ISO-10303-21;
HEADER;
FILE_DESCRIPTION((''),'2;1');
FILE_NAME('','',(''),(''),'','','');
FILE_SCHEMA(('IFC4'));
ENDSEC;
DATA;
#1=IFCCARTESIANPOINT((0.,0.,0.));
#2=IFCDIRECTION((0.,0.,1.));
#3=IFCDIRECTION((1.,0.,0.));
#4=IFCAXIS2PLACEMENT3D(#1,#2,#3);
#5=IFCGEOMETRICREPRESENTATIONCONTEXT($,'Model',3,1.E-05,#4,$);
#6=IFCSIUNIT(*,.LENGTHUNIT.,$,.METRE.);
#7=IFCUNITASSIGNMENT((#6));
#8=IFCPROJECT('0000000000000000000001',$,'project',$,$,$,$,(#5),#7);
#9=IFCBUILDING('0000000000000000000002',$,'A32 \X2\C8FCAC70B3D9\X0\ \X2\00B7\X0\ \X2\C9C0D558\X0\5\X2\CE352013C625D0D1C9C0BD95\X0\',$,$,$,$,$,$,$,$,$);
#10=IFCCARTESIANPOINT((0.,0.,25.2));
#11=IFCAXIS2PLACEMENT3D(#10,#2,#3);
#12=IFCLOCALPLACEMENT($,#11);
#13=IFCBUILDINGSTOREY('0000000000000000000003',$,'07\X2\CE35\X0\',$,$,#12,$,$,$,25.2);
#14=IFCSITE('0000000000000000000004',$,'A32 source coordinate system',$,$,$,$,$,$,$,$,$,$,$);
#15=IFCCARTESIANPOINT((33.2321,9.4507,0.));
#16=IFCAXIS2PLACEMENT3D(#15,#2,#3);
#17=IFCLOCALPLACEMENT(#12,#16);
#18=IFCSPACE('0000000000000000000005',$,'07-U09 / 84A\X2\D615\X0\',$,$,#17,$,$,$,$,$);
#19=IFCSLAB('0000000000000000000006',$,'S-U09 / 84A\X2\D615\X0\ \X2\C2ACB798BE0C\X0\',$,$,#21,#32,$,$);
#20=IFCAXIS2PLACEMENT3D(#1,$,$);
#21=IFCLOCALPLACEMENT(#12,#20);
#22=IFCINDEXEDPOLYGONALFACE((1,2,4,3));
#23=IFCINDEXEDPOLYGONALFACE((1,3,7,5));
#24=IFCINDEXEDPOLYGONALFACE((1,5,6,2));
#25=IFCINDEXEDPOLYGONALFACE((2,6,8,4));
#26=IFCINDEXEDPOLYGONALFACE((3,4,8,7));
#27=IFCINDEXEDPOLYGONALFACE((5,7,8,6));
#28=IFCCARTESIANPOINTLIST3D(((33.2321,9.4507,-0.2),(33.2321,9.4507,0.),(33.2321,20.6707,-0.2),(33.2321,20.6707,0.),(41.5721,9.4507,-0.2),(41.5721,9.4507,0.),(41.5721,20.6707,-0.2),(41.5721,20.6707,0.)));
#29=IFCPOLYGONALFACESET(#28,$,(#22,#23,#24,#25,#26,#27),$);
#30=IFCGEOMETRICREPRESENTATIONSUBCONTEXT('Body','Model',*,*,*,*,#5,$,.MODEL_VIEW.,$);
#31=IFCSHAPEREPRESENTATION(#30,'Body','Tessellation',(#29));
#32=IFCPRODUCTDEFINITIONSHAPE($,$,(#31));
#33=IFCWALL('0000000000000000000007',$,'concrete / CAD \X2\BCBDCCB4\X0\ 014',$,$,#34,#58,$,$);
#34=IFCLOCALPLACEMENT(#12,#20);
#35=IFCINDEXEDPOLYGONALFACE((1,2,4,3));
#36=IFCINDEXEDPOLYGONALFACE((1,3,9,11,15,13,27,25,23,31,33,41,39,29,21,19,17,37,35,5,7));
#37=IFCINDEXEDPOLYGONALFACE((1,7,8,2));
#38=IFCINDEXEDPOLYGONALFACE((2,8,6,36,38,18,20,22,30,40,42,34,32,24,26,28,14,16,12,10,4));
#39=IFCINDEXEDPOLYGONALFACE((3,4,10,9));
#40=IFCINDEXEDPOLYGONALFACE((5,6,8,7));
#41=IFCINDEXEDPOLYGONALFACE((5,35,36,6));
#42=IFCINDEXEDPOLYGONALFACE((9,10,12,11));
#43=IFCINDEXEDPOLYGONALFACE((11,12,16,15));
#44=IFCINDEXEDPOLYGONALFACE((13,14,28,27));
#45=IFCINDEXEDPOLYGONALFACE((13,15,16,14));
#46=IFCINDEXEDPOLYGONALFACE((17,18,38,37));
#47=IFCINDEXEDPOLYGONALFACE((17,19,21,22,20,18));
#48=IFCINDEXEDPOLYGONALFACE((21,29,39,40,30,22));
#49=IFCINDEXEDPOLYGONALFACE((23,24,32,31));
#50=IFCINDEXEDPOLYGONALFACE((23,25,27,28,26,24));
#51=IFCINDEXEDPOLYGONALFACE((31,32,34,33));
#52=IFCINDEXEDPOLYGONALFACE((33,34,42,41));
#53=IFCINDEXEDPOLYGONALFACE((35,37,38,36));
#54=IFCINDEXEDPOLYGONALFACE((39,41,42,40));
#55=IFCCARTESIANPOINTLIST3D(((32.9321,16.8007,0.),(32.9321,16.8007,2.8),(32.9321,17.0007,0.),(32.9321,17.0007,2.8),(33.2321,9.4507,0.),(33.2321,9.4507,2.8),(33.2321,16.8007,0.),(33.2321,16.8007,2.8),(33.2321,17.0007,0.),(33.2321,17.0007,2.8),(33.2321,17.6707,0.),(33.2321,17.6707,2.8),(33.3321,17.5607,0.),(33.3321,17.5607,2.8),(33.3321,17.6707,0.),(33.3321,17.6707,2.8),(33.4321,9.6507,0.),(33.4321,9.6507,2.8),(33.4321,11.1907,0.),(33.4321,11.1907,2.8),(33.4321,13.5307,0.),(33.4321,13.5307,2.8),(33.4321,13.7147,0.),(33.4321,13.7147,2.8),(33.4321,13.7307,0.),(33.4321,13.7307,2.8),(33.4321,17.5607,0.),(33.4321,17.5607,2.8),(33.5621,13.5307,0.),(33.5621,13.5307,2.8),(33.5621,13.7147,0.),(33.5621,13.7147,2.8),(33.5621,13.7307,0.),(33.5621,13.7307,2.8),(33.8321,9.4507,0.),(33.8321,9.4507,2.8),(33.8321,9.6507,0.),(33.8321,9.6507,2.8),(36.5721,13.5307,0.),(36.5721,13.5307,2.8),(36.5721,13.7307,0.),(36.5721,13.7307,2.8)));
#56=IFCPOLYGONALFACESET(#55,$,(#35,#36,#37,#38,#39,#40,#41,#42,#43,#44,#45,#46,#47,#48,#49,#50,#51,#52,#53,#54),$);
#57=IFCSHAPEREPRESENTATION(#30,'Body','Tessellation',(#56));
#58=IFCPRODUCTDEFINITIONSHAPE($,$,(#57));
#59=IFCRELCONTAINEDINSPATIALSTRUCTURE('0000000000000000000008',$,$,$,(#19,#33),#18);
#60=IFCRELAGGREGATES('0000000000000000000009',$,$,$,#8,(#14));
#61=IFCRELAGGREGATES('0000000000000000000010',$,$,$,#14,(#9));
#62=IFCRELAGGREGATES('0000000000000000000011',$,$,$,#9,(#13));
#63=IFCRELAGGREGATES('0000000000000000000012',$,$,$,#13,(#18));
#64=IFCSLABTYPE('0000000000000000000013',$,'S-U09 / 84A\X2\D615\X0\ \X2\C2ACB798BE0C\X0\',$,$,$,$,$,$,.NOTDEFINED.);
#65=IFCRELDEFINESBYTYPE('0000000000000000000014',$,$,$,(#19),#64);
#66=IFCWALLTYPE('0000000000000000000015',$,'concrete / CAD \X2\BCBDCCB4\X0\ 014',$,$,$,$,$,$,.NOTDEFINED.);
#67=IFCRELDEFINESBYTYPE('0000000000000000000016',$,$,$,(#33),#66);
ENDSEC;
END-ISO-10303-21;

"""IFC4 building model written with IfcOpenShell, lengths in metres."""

from ifc_helpers import new_model, si_unit, frame, origin, origin_with_axes, place, context, subcontext, project, spatial, polyline, outline, extrude, source, transform, mapped, type_object, type_shapes, element, save


model = new_model("IFC4")

# Units and contexts
model_context = context("Model", 3, precision=1e-05, world=origin_with_axes())
body_context = subcontext(model_context, "Body", "Model", "MODEL_VIEW")
ifc_project = project(units=[si_unit("LENGTHUNIT", "METRE")], contexts=[model_context])

# Site, building, storey, space
storey_placement = place(None, frame((0.0, 0.0, 25.2), z_axis=(0.0, 0.0, 1.0), x_axis=(1.0, 0.0, 0.0)))
space_placement = place(storey_placement, frame((33.2321, 9.4507, 0.0), z_axis=(0.0, 0.0, 1.0), x_axis=(1.0, 0.0, 0.0)))
site = spatial("IfcSite", under=ifc_project, Name="A32 source coordinate system")
building = spatial("IfcBuilding", under=site, Name="A32 주거동 · 지하5층–옥탑지붕")
storey = spatial("IfcBuildingStorey", under=building, at=storey_placement, Name="07층", Elevation=25.2)
space = spatial("IfcSpace", under=storey, at=space_placement, Name="07-U09 / 84A형")

# Slab
slab_type_1 = type_object("IfcSlabType", Name="S-U09 / 84A형 슬래브", PredefinedType="NOTDEFINED")
shared_shape_1 = source(origin(), body_context, "Body", "SweptSolid", [
    extrude(outline(polyline([(0.0, 11.22), (8.34, 11.22), (8.34, 0.0), (0.0, 0.0), (0.0, 11.22)])), frame((0.0, 0.0, -0.2)), (0.0, 0.0, 1.0), 0.2),
])
type_shapes(slab_type_1, [shared_shape_1])
slab_1_placement = place(space_placement, origin_with_axes())
element("IfcSlab", 1, at=slab_1_placement, inside=space, type_object=slab_type_1, Name="S-U09 / 84A형 슬래브", context=body_context, shape_type="MappedRepresentation", body=[
    mapped(shared_shape_1, transform((0.0, 0.0, 0.0), scale=1.0)),
])

# Wall
wall_type_1 = type_object("IfcWallType", Name="concrete / CAD 벽체 014", PredefinedType="NOTDEFINED")
shared_shape_2 = source(origin(), body_context, "Body", "SweptSolid", [
    extrude(outline(polyline([(3.34, 4.08), (0.33, 4.08), (0.2, 4.08), (0.2, 1.74), (0.2, 0.2), (0.6, 0.2), (0.6, 0.0), (0.0, 0.0), (0.0, 7.35), (-0.3, 7.35), (-0.3, 7.55), (0.0, 7.55), (0.0, 8.22), (0.1, 8.22), (0.1, 8.11), (0.2, 8.11), (0.2, 4.28), (0.2, 4.264), (0.33, 4.264), (0.33, 4.28), (3.34, 4.28), (3.34, 4.08)])), origin(), (0.0, 0.0, 1.0), 2.8),
])
type_shapes(wall_type_1, [shared_shape_2])
wall_1_placement = place(space_placement, origin_with_axes())
element("IfcWall", 2, at=wall_1_placement, inside=space, type_object=wall_type_1, Name="concrete / CAD 벽체 014", context=body_context, shape_type="MappedRepresentation", body=[
    mapped(shared_shape_2, transform((0.0, 0.0, 0.0), scale=1.0)),
])

save(model, "model.ifc")
